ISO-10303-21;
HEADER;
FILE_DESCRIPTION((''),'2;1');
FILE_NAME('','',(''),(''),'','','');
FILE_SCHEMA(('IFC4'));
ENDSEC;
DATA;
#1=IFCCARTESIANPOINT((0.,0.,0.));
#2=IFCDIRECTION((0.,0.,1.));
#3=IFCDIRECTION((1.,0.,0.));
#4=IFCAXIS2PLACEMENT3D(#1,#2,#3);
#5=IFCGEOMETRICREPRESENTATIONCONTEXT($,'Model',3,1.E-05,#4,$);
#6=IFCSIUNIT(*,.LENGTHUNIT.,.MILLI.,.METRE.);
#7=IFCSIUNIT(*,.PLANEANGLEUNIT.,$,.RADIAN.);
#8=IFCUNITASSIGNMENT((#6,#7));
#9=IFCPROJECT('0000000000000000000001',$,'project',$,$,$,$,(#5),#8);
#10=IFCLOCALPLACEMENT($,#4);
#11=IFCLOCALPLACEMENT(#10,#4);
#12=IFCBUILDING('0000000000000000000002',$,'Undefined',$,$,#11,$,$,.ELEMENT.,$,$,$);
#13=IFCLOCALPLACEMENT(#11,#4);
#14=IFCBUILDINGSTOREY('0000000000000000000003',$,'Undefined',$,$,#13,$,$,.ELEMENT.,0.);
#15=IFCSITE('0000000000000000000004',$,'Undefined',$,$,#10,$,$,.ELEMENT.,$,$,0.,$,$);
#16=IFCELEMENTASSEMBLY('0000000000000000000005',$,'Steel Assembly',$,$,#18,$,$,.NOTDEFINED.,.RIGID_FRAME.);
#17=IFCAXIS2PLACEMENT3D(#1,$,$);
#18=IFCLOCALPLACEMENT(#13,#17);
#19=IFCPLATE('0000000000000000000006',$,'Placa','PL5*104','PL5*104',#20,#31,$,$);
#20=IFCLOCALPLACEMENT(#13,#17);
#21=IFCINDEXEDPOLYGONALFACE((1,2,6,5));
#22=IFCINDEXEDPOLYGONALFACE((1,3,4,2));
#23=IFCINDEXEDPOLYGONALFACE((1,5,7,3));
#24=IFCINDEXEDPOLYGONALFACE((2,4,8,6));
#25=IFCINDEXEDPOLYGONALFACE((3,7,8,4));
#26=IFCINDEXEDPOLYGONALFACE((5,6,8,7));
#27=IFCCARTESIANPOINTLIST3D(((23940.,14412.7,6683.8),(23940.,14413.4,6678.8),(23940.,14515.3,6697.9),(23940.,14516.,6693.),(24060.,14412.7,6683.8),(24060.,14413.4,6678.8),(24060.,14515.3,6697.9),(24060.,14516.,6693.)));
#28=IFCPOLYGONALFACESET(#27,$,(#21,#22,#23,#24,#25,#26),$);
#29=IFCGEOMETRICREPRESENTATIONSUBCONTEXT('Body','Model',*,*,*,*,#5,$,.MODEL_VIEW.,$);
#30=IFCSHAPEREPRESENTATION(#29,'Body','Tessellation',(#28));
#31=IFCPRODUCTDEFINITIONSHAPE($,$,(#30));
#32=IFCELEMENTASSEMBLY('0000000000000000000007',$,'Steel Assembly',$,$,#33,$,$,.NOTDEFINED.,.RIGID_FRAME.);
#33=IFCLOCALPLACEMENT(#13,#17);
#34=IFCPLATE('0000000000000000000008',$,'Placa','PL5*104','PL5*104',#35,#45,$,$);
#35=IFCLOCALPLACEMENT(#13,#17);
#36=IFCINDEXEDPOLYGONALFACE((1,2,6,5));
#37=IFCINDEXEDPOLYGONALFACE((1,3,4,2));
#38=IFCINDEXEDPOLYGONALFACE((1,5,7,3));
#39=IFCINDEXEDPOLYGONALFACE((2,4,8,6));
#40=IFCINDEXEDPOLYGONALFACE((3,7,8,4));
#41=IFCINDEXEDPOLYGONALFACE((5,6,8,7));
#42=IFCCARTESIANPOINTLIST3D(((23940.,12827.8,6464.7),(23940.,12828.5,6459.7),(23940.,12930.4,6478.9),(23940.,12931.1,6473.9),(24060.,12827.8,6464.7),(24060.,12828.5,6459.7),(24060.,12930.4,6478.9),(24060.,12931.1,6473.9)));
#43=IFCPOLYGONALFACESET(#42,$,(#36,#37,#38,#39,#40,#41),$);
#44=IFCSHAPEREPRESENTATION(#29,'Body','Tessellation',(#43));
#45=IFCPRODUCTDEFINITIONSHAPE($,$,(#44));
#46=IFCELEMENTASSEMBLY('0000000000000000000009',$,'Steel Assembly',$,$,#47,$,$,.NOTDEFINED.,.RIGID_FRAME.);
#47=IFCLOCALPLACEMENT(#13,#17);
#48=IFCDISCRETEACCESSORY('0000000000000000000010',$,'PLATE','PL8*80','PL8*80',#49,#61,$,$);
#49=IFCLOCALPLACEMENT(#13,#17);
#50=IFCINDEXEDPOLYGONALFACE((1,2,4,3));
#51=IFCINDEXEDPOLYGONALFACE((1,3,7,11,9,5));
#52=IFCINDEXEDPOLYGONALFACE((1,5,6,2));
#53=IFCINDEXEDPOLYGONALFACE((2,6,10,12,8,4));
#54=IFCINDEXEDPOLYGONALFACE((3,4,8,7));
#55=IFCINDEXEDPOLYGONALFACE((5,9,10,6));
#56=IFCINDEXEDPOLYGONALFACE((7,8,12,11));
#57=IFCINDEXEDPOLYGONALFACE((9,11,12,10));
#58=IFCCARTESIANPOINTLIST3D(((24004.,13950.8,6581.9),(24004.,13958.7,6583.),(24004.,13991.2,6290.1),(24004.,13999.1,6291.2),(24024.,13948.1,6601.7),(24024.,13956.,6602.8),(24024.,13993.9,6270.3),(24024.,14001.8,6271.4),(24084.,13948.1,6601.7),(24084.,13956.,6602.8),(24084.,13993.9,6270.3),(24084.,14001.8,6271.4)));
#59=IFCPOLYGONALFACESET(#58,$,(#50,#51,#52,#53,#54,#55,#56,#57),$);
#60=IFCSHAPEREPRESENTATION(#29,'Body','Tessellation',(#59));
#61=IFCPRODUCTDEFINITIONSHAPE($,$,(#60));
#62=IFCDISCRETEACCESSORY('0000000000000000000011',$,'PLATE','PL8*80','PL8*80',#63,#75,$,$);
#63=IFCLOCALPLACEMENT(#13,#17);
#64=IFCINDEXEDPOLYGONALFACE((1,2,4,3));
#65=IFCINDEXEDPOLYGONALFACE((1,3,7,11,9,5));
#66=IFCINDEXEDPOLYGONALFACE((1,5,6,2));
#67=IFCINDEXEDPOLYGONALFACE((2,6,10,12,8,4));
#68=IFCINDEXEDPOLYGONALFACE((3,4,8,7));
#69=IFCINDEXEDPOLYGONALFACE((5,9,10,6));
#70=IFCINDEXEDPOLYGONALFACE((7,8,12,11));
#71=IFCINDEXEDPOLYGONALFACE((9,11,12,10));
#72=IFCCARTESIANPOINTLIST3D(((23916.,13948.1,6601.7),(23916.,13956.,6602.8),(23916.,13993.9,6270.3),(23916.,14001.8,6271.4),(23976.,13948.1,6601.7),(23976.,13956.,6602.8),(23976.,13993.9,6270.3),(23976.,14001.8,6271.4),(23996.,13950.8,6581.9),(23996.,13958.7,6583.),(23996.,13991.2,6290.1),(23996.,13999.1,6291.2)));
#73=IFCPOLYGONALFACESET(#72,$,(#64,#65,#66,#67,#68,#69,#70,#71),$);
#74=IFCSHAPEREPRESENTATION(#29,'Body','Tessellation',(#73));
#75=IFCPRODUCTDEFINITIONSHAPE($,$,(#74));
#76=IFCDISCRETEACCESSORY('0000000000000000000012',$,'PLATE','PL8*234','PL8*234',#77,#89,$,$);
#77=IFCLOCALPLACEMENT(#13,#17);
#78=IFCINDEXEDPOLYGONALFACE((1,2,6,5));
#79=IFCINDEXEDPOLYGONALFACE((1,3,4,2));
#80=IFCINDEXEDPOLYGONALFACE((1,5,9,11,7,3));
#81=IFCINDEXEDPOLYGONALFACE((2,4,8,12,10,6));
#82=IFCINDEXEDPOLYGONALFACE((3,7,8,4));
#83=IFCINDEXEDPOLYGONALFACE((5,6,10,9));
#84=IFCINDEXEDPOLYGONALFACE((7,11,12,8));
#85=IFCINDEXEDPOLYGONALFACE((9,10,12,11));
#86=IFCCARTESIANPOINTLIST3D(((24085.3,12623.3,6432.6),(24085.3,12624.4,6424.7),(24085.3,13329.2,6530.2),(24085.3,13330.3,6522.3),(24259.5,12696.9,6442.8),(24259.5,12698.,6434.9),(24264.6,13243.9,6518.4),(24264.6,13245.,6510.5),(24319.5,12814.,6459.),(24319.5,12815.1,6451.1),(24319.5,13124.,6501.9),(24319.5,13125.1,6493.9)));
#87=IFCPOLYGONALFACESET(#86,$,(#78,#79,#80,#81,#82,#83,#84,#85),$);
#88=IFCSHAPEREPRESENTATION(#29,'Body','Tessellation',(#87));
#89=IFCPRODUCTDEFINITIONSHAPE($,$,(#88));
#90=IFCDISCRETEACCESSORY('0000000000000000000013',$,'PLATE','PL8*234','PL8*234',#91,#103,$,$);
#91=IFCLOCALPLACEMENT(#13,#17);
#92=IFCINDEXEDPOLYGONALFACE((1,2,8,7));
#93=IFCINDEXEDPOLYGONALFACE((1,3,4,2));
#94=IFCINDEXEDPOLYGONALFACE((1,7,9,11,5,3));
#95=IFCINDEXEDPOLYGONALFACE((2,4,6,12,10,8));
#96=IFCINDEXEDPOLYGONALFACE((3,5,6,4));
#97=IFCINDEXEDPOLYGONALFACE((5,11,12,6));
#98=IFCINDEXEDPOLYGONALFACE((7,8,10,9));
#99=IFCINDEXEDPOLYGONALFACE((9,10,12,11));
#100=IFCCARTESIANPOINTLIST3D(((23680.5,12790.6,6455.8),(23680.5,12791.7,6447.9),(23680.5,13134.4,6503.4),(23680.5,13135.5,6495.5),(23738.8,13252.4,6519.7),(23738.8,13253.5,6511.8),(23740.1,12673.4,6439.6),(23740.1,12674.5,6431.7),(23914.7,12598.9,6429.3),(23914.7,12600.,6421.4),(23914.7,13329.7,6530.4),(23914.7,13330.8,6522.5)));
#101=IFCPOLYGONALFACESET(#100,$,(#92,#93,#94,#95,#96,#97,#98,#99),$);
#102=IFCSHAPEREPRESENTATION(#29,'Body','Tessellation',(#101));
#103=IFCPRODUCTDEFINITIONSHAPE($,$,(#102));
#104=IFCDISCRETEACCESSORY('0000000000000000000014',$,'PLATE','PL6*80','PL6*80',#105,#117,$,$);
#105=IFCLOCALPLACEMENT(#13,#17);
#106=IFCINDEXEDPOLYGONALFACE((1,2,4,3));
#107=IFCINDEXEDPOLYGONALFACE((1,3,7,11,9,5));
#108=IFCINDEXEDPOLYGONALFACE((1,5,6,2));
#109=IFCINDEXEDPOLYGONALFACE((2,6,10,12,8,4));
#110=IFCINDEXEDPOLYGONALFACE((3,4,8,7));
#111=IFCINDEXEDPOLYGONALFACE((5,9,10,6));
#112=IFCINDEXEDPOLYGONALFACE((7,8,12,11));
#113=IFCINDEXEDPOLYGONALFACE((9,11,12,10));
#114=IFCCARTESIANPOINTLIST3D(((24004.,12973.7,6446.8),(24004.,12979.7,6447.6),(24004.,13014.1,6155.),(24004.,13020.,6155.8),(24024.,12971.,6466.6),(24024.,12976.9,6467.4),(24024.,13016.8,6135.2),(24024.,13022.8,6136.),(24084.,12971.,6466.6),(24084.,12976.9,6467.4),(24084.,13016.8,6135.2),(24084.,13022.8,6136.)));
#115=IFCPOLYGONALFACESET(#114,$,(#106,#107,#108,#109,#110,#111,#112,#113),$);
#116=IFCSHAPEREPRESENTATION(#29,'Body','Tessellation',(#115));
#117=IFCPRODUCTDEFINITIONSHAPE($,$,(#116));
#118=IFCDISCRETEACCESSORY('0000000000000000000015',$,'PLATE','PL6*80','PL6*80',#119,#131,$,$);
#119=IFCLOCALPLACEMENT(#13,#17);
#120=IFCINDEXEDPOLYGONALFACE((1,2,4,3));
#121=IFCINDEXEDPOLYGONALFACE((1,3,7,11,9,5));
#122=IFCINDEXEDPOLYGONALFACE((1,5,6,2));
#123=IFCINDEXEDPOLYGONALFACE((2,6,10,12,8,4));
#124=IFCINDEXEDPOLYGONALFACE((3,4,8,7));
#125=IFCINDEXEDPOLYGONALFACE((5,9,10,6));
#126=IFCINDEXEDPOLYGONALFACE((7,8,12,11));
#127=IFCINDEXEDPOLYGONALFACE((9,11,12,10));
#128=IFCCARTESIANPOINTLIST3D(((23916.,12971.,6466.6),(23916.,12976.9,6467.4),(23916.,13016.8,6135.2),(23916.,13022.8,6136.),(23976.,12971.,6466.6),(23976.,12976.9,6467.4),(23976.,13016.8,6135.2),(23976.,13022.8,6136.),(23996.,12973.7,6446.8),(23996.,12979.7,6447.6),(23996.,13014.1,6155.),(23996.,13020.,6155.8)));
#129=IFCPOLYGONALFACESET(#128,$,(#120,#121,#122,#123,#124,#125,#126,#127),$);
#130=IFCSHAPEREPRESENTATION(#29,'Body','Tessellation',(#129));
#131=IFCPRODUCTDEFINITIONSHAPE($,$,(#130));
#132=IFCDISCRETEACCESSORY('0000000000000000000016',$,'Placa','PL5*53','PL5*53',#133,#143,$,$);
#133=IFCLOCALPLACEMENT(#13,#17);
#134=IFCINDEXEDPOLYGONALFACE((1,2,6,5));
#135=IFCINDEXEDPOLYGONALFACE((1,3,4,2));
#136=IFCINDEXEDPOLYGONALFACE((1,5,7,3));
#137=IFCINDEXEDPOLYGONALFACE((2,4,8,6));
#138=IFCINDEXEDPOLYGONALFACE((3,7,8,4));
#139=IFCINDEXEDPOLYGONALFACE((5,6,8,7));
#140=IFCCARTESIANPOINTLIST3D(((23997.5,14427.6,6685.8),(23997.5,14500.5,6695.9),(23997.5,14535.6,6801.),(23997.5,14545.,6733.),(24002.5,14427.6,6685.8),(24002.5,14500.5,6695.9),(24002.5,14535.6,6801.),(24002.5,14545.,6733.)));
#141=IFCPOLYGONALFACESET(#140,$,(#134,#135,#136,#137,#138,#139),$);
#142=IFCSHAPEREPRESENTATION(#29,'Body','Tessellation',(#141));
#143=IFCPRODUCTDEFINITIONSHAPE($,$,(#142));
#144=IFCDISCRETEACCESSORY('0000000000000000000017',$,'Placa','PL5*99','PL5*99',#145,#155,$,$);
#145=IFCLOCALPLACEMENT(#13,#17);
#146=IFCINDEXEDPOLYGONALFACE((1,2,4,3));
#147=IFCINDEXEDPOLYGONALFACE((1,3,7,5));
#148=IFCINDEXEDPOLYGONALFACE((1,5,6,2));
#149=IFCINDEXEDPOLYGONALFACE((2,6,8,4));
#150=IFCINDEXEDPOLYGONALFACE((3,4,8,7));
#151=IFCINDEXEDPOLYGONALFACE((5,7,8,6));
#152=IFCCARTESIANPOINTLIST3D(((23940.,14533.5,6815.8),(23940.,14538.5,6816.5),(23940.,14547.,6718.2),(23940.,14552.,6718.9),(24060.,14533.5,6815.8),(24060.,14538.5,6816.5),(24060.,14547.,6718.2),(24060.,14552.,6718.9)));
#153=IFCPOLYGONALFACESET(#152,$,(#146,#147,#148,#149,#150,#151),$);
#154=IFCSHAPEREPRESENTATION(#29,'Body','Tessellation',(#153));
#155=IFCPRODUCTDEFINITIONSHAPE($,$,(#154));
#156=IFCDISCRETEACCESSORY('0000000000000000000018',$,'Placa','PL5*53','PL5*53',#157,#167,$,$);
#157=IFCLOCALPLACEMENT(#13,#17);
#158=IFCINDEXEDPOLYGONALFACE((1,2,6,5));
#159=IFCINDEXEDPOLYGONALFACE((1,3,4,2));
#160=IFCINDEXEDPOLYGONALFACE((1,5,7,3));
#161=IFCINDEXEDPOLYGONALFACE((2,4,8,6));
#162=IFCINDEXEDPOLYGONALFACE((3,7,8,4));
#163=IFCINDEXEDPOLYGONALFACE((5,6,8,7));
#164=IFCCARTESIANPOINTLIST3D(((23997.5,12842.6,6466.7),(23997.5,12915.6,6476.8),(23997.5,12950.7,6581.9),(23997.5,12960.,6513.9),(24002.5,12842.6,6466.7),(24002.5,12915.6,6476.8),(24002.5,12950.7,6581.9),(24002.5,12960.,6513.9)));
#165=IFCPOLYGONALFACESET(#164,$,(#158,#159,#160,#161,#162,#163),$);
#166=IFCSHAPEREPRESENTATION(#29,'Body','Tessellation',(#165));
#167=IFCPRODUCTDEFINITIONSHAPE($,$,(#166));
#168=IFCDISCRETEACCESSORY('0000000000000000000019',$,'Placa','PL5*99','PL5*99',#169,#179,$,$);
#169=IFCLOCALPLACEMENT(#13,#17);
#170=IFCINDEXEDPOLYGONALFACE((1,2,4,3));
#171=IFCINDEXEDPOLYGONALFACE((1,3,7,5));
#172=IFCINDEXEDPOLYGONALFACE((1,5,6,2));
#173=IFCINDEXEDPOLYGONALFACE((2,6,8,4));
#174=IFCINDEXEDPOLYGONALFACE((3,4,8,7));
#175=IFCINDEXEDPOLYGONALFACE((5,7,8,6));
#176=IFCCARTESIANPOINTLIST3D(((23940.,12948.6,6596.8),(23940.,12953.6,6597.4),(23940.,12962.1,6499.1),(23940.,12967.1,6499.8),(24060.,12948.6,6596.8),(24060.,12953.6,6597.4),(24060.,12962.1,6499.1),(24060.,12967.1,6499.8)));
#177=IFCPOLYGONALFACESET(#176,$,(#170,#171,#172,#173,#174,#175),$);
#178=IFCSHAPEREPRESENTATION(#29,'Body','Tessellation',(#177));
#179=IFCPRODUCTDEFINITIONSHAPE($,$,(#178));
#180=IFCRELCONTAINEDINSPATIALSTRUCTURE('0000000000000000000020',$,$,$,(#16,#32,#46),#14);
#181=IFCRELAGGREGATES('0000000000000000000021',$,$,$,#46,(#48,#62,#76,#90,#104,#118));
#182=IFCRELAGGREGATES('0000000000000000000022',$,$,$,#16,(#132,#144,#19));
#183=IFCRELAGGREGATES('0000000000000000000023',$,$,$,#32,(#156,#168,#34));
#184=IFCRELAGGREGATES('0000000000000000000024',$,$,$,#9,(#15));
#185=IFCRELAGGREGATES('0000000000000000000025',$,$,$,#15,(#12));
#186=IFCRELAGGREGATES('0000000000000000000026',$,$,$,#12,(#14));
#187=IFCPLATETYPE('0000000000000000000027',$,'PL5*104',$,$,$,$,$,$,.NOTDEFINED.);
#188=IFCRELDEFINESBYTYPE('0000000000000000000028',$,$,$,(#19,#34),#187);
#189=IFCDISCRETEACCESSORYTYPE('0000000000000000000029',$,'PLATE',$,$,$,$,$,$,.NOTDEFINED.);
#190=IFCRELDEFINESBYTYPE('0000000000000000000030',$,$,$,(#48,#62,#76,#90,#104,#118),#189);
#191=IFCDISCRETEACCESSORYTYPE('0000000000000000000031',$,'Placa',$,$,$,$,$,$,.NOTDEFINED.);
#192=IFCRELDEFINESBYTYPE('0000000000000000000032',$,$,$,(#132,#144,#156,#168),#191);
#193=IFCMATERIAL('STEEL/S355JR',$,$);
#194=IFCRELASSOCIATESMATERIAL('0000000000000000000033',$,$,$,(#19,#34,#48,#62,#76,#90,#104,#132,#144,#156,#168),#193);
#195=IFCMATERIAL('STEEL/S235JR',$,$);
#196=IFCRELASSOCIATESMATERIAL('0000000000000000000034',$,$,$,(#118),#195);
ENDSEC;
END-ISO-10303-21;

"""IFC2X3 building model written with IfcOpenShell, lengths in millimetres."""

from ifc_helpers import new_model, si_unit, frame, origin_with_axes, place, context, subcontext, project, spatial, polyline, outline, extrude, material, type_object, element, aggregate, save


model = new_model("IFC2X3")

# Units and contexts
model_context = context("Model", 3, precision=1e-05, world=origin_with_axes())
body_context = subcontext(model_context, "Body", "Model", "MODEL_VIEW")
ifc_project = project(units=[si_unit("LENGTHUNIT", "METRE", prefix="MILLI"), si_unit("PLANEANGLEUNIT", "RADIAN")], contexts=[model_context])

# Site, building, storey
site_placement = place(None, origin_with_axes())
site = spatial("IfcSite", under=ifc_project, at=site_placement, Name="Undefined", CompositionType="ELEMENT", RefElevation=0.0)
building_placement = place(site_placement, origin_with_axes())
building = spatial("IfcBuilding", under=site, at=building_placement, Name="Undefined", CompositionType="ELEMENT")
storey_placement = place(building_placement, origin_with_axes())
storey = spatial("IfcBuildingStorey", under=building, at=storey_placement, Name="Undefined", CompositionType="ELEMENT", Elevation=0.0)

# Shared definitions
ifc_material_1 = material(Name="STEEL/S355JR")

# Element assemblies, plates
assembly_1_placement = place(storey_placement, origin_with_axes())
assembly_1 = element("IfcElementAssembly", 1, at=assembly_1_placement, inside=storey, Name="Steel Assembly", AssemblyPlace="NOTDEFINED", PredefinedType="RIGID_FRAME")
plate_type = type_object("IfcPlateType", Name="PL5*104", PredefinedType="NOTDEFINED")
plate_1_placement = place(assembly_1_placement, frame((23940.0, 14515.7, 6695.5), z_axis=(0.0, -0.136905, 0.990584), x_axis=(0.0, -0.990584, -0.136905)))
plate_1 = element("IfcPlate", 2, at=plate_1_placement, type_object=plate_type, material=ifc_material_1, Name="Placa", Description="PL5*104", ObjectType="PL5*104", context=body_context, shape_type="SweptSolid", body=[
    extrude(outline(polyline([(0.0, 0.0), (103.6, 0.0), (103.6, 120.0), (0.0, 120.0), (0.0, 0.0)])), frame((0.0, 0.0, -2.5), z_axis=(0.0, 0.0, 1.0), x_axis=(1.0, 0.0, 0.0)), (0.0, 0.0, 1.0), 5.0),
])
assembly_2_placement = place(storey_placement, origin_with_axes())
assembly_2 = element("IfcElementAssembly", 3, at=assembly_2_placement, inside=storey, Name="Steel Assembly", AssemblyPlace="NOTDEFINED", PredefinedType="RIGID_FRAME")
plate_2_placement = place(assembly_2_placement, frame((23940.0, 12930.8, 6476.4), z_axis=(0.0, -0.136905, 0.990584), x_axis=(0.0, -0.990584, -0.136905)))
plate_2 = element("IfcPlate", 4, at=plate_2_placement, type_object=plate_type, material=ifc_material_1, Name="Placa", Description="PL5*104", ObjectType="PL5*104", context=body_context, shape_type="SweptSolid", body=[
    extrude(outline(polyline([(0.0, 0.0), (103.6, 0.0), (103.6, 120.0), (0.0, 120.0), (0.0, 0.0)])), frame((0.0, 0.0, -2.5), z_axis=(0.0, 0.0, 1.0), x_axis=(1.0, 0.0, 0.0)), (0.0, 0.0, 1.0), 5.0),
])

# Element assembly, discrete accessories
assembly_3_placement = place(storey_placement, origin_with_axes())
assembly_3 = element("IfcElementAssembly", 5, at=assembly_3_placement, inside=storey, Name="Steel Assembly", AssemblyPlace="NOTDEFINED", PredefinedType="RIGID_FRAME")
discrete_accessory_type_1 = type_object("IfcDiscreteAccessoryType", Name="PLATE")
discrete_accessory_1_placement = place(assembly_3_placement, frame((24084.0, 13997.9, 6270.8), z_axis=(0.0, 0.990574, 0.13698), x_axis=(-1.0, 0.0, 0.0)))
discrete_accessory_1 = element("IfcDiscreteAccessory", 6, at=discrete_accessory_1_placement, type_object=discrete_accessory_type_1, material=ifc_material_1, Name="PLATE", Description="PL8*80", ObjectType="PL8*80", context=body_context, shape_type="SweptSolid", body=[
    extrude(outline(polyline([(0.0, 0.0), (60.0, 0.0), (80.0, 20.0), (80.0, 314.6), (60.0, 334.6), (0.0, 334.6), (0.0, 0.0)])), frame((0.0, 0.0, -4.0), z_axis=(0.0, 0.0, 1.0), x_axis=(1.0, 0.0, 0.0)), (0.0, 0.0, 1.0), 8.0),
])
discrete_accessory_2_placement = place(assembly_3_placement, frame((23996.0, 13997.9, 6270.8), z_axis=(0.0, 0.990574, 0.13698), x_axis=(-1.0, 0.0, 0.0)))
discrete_accessory_2 = element("IfcDiscreteAccessory", 7, at=discrete_accessory_2_placement, type_object=discrete_accessory_type_1, material=ifc_material_1, Name="PLATE", Description="PL8*80", ObjectType="PL8*80", context=body_context, shape_type="SweptSolid", body=[
    extrude(outline(polyline([(0.0, 20.0), (20.0, 0.0), (80.0, 0.0), (80.0, 334.6), (20.0, 334.6), (0.0, 314.6), (0.0, 20.0)])), frame((0.0, 0.0, -4.0), z_axis=(0.0, 0.0, 1.0), x_axis=(1.0, 0.0, 0.0)), (0.0, 0.0, 1.0), 8.0),
])
discrete_accessory_3_placement = place(assembly_3_placement, frame((24085.3, 13329.7, 6526.3), z_axis=(-0.000018, -0.13698, 0.990574), x_axis=(0.0, -0.990574, -0.13698)))
discrete_accessory_3 = element("IfcDiscreteAccessory", 8, at=discrete_accessory_3_placement, type_object=discrete_accessory_type_1, material=ifc_material_1, Name="PLATE", Description="PL8*234", ObjectType="PL8*234", context=body_context, shape_type="SweptSolid", body=[
    extrude(outline(polyline([(0.0, 0.0), (712.6, 0.0), (638.3, 174.2), (520.1, 234.3), (207.1, 234.3), (86.0, 179.4), (0.0, 0.0)])), frame((0.0, 0.0, -4.0), z_axis=(0.0, 0.0, 1.0), x_axis=(1.0, 0.0, 0.0)), (0.0, 0.0, 1.0), 8.0),
])
discrete_accessory_4_placement = place(assembly_3_placement, frame((23914.7, 12599.5, 6425.4), z_axis=(-0.000018, -0.13698, 0.990574), x_axis=(0.0, 0.990574, 0.13698)))
discrete_accessory_4 = element("IfcDiscreteAccessory", 9, at=discrete_accessory_4_placement, type_object=discrete_accessory_type_1, material=ifc_material_1, Name="PLATE", Description="PL8*234", ObjectType="PL8*234", context=body_context, shape_type="SweptSolid", body=[
    extrude(outline(polyline([(0.0, 0.0), (737.8, 0.0), (659.7, 175.9), (540.6, 234.3), (193.6, 234.3), (75.2, 174.6), (0.0, 0.0)])), frame((0.0, 0.0, -4.0), z_axis=(0.0, 0.0, 1.0), x_axis=(1.0, 0.0, 0.0)), (0.0, 0.0, 1.0), 8.0),
])
discrete_accessory_5_placement = place(assembly_3_placement, frame((24084.0, 13019.8, 6135.6), z_axis=(0.0, 0.990574, 0.13698), x_axis=(-1.0, 0.0, 0.0)))
discrete_accessory_5 = element("IfcDiscreteAccessory", 10, at=discrete_accessory_5_placement, type_object=discrete_accessory_type_1, material=ifc_material_1, Name="PLATE", Description="PL6*80", ObjectType="PL6*80", context=body_context, shape_type="SweptSolid", body=[
    extrude(outline(polyline([(0.0, 0.0), (60.0, 0.0), (80.0, 20.0), (80.0, 314.6), (60.0, 334.6), (0.0, 334.6), (0.0, 0.0)])), frame((0.0, 0.0, -3.0), z_axis=(0.0, 0.0, 1.0), x_axis=(1.0, 0.0, 0.0)), (0.0, 0.0, 1.0), 6.0),
])
ifc_material_2 = material(Name="STEEL/S235JR")
discrete_accessory_6_placement = place(assembly_3_placement, frame((23996.0, 13019.8, 6135.6), z_axis=(0.0, 0.990574, 0.13698), x_axis=(-1.0, 0.0, 0.0)))
discrete_accessory_6 = element("IfcDiscreteAccessory", 11, at=discrete_accessory_6_placement, type_object=discrete_accessory_type_1, material=ifc_material_2, Name="PLATE", Description="PL6*80", ObjectType="PL6*80", context=body_context, shape_type="SweptSolid", body=[
    extrude(outline(polyline([(0.0, 20.0), (20.0, 0.0), (80.0, 0.0), (80.0, 334.6), (20.0, 334.6), (0.0, 314.6), (0.0, 20.0)])), frame((0.0, 0.0, -3.0), z_axis=(0.0, 0.0, 1.0), x_axis=(1.0, 0.0, 0.0)), (0.0, 0.0, 1.0), 6.0),
])

# Discrete accessories
discrete_accessory_type_2 = type_object("IfcDiscreteAccessoryType", Name="Placa")
discrete_accessory_7_placement = place(assembly_1_placement, frame((24000.0, 14535.6, 6801.0), z_axis=(1.0, 0.0, 0.0), x_axis=(0.0, -0.684057, -0.729429)))
discrete_accessory_7 = element("IfcDiscreteAccessory", 12, at=discrete_accessory_7_placement, type_object=discrete_accessory_type_2, material=ifc_material_1, Name="Placa", Description="PL5*53", ObjectType="PL5*53", context=body_context, shape_type="SweptSolid", body=[
    extrude(outline(polyline([(0.0, 0.0), (157.9, 0.0), (100.7, 46.3), (43.1, 53.3), (0.0, 0.0)])), frame((0.0, 0.0, -2.5), z_axis=(0.0, 0.0, 1.0), x_axis=(1.0, 0.0, 0.0)), (0.0, 0.0, 1.0), 5.0),
])
discrete_accessory_8_placement = place(assembly_1_placement, frame((23940.0, 14549.5, 6718.5), z_axis=(0.0, 0.990592, 0.136849), x_axis=(0.0, -0.136849, 0.990592)))
discrete_accessory_8 = element("IfcDiscreteAccessory", 13, at=discrete_accessory_8_placement, type_object=discrete_accessory_type_2, material=ifc_material_1, Name="Placa", Description="PL5*99", ObjectType="PL5*99", context=body_context, shape_type="SweptSolid", body=[
    extrude(outline(polyline([(0.0, 0.0), (98.6, 0.0), (98.6, 120.0), (0.0, 120.0), (0.0, 0.0)])), frame((0.0, 0.0, -2.5), z_axis=(0.0, 0.0, 1.0), x_axis=(1.0, 0.0, 0.0)), (0.0, 0.0, 1.0), 5.0),
])
discrete_accessory_9_placement = place(assembly_2_placement, frame((24000.0, 12950.7, 6581.9), z_axis=(1.0, 0.0, 0.0), x_axis=(0.0, -0.684057, -0.729429)))
discrete_accessory_9 = element("IfcDiscreteAccessory", 14, at=discrete_accessory_9_placement, type_object=discrete_accessory_type_2, material=ifc_material_1, Name="Placa", Description="PL5*53", ObjectType="PL5*53", context=body_context, shape_type="SweptSolid", body=[
    extrude(outline(polyline([(0.0, 0.0), (157.9, 0.0), (100.7, 46.3), (43.1, 53.3), (0.0, 0.0)])), frame((0.0, 0.0, -2.5), z_axis=(0.0, 0.0, 1.0), x_axis=(1.0, 0.0, 0.0)), (0.0, 0.0, 1.0), 5.0),
])
discrete_accessory_10_placement = place(assembly_2_placement, frame((23940.0, 12964.6, 6499.4), z_axis=(0.0, 0.990592, 0.136849), x_axis=(0.0, -0.136849, 0.990592)))
discrete_accessory_10 = element("IfcDiscreteAccessory", 15, at=discrete_accessory_10_placement, type_object=discrete_accessory_type_2, material=ifc_material_1, Name="Placa", Description="PL5*99", ObjectType="PL5*99", context=body_context, shape_type="SweptSolid", body=[
    extrude(outline(polyline([(0.0, 0.0), (98.6, 0.0), (98.6, 120.0), (0.0, 120.0), (0.0, 0.0)])), frame((0.0, 0.0, -2.5), z_axis=(0.0, 0.0, 1.0), x_axis=(1.0, 0.0, 0.0)), (0.0, 0.0, 1.0), 5.0),
])

aggregate(assembly_3, [discrete_accessory_1, discrete_accessory_2, discrete_accessory_3, discrete_accessory_4, discrete_accessory_5, discrete_accessory_6])

aggregate(assembly_1, [discrete_accessory_7, discrete_accessory_8, plate_1])
aggregate(assembly_2, [discrete_accessory_9, discrete_accessory_10, plate_2])

save(model, "model.ifc")
